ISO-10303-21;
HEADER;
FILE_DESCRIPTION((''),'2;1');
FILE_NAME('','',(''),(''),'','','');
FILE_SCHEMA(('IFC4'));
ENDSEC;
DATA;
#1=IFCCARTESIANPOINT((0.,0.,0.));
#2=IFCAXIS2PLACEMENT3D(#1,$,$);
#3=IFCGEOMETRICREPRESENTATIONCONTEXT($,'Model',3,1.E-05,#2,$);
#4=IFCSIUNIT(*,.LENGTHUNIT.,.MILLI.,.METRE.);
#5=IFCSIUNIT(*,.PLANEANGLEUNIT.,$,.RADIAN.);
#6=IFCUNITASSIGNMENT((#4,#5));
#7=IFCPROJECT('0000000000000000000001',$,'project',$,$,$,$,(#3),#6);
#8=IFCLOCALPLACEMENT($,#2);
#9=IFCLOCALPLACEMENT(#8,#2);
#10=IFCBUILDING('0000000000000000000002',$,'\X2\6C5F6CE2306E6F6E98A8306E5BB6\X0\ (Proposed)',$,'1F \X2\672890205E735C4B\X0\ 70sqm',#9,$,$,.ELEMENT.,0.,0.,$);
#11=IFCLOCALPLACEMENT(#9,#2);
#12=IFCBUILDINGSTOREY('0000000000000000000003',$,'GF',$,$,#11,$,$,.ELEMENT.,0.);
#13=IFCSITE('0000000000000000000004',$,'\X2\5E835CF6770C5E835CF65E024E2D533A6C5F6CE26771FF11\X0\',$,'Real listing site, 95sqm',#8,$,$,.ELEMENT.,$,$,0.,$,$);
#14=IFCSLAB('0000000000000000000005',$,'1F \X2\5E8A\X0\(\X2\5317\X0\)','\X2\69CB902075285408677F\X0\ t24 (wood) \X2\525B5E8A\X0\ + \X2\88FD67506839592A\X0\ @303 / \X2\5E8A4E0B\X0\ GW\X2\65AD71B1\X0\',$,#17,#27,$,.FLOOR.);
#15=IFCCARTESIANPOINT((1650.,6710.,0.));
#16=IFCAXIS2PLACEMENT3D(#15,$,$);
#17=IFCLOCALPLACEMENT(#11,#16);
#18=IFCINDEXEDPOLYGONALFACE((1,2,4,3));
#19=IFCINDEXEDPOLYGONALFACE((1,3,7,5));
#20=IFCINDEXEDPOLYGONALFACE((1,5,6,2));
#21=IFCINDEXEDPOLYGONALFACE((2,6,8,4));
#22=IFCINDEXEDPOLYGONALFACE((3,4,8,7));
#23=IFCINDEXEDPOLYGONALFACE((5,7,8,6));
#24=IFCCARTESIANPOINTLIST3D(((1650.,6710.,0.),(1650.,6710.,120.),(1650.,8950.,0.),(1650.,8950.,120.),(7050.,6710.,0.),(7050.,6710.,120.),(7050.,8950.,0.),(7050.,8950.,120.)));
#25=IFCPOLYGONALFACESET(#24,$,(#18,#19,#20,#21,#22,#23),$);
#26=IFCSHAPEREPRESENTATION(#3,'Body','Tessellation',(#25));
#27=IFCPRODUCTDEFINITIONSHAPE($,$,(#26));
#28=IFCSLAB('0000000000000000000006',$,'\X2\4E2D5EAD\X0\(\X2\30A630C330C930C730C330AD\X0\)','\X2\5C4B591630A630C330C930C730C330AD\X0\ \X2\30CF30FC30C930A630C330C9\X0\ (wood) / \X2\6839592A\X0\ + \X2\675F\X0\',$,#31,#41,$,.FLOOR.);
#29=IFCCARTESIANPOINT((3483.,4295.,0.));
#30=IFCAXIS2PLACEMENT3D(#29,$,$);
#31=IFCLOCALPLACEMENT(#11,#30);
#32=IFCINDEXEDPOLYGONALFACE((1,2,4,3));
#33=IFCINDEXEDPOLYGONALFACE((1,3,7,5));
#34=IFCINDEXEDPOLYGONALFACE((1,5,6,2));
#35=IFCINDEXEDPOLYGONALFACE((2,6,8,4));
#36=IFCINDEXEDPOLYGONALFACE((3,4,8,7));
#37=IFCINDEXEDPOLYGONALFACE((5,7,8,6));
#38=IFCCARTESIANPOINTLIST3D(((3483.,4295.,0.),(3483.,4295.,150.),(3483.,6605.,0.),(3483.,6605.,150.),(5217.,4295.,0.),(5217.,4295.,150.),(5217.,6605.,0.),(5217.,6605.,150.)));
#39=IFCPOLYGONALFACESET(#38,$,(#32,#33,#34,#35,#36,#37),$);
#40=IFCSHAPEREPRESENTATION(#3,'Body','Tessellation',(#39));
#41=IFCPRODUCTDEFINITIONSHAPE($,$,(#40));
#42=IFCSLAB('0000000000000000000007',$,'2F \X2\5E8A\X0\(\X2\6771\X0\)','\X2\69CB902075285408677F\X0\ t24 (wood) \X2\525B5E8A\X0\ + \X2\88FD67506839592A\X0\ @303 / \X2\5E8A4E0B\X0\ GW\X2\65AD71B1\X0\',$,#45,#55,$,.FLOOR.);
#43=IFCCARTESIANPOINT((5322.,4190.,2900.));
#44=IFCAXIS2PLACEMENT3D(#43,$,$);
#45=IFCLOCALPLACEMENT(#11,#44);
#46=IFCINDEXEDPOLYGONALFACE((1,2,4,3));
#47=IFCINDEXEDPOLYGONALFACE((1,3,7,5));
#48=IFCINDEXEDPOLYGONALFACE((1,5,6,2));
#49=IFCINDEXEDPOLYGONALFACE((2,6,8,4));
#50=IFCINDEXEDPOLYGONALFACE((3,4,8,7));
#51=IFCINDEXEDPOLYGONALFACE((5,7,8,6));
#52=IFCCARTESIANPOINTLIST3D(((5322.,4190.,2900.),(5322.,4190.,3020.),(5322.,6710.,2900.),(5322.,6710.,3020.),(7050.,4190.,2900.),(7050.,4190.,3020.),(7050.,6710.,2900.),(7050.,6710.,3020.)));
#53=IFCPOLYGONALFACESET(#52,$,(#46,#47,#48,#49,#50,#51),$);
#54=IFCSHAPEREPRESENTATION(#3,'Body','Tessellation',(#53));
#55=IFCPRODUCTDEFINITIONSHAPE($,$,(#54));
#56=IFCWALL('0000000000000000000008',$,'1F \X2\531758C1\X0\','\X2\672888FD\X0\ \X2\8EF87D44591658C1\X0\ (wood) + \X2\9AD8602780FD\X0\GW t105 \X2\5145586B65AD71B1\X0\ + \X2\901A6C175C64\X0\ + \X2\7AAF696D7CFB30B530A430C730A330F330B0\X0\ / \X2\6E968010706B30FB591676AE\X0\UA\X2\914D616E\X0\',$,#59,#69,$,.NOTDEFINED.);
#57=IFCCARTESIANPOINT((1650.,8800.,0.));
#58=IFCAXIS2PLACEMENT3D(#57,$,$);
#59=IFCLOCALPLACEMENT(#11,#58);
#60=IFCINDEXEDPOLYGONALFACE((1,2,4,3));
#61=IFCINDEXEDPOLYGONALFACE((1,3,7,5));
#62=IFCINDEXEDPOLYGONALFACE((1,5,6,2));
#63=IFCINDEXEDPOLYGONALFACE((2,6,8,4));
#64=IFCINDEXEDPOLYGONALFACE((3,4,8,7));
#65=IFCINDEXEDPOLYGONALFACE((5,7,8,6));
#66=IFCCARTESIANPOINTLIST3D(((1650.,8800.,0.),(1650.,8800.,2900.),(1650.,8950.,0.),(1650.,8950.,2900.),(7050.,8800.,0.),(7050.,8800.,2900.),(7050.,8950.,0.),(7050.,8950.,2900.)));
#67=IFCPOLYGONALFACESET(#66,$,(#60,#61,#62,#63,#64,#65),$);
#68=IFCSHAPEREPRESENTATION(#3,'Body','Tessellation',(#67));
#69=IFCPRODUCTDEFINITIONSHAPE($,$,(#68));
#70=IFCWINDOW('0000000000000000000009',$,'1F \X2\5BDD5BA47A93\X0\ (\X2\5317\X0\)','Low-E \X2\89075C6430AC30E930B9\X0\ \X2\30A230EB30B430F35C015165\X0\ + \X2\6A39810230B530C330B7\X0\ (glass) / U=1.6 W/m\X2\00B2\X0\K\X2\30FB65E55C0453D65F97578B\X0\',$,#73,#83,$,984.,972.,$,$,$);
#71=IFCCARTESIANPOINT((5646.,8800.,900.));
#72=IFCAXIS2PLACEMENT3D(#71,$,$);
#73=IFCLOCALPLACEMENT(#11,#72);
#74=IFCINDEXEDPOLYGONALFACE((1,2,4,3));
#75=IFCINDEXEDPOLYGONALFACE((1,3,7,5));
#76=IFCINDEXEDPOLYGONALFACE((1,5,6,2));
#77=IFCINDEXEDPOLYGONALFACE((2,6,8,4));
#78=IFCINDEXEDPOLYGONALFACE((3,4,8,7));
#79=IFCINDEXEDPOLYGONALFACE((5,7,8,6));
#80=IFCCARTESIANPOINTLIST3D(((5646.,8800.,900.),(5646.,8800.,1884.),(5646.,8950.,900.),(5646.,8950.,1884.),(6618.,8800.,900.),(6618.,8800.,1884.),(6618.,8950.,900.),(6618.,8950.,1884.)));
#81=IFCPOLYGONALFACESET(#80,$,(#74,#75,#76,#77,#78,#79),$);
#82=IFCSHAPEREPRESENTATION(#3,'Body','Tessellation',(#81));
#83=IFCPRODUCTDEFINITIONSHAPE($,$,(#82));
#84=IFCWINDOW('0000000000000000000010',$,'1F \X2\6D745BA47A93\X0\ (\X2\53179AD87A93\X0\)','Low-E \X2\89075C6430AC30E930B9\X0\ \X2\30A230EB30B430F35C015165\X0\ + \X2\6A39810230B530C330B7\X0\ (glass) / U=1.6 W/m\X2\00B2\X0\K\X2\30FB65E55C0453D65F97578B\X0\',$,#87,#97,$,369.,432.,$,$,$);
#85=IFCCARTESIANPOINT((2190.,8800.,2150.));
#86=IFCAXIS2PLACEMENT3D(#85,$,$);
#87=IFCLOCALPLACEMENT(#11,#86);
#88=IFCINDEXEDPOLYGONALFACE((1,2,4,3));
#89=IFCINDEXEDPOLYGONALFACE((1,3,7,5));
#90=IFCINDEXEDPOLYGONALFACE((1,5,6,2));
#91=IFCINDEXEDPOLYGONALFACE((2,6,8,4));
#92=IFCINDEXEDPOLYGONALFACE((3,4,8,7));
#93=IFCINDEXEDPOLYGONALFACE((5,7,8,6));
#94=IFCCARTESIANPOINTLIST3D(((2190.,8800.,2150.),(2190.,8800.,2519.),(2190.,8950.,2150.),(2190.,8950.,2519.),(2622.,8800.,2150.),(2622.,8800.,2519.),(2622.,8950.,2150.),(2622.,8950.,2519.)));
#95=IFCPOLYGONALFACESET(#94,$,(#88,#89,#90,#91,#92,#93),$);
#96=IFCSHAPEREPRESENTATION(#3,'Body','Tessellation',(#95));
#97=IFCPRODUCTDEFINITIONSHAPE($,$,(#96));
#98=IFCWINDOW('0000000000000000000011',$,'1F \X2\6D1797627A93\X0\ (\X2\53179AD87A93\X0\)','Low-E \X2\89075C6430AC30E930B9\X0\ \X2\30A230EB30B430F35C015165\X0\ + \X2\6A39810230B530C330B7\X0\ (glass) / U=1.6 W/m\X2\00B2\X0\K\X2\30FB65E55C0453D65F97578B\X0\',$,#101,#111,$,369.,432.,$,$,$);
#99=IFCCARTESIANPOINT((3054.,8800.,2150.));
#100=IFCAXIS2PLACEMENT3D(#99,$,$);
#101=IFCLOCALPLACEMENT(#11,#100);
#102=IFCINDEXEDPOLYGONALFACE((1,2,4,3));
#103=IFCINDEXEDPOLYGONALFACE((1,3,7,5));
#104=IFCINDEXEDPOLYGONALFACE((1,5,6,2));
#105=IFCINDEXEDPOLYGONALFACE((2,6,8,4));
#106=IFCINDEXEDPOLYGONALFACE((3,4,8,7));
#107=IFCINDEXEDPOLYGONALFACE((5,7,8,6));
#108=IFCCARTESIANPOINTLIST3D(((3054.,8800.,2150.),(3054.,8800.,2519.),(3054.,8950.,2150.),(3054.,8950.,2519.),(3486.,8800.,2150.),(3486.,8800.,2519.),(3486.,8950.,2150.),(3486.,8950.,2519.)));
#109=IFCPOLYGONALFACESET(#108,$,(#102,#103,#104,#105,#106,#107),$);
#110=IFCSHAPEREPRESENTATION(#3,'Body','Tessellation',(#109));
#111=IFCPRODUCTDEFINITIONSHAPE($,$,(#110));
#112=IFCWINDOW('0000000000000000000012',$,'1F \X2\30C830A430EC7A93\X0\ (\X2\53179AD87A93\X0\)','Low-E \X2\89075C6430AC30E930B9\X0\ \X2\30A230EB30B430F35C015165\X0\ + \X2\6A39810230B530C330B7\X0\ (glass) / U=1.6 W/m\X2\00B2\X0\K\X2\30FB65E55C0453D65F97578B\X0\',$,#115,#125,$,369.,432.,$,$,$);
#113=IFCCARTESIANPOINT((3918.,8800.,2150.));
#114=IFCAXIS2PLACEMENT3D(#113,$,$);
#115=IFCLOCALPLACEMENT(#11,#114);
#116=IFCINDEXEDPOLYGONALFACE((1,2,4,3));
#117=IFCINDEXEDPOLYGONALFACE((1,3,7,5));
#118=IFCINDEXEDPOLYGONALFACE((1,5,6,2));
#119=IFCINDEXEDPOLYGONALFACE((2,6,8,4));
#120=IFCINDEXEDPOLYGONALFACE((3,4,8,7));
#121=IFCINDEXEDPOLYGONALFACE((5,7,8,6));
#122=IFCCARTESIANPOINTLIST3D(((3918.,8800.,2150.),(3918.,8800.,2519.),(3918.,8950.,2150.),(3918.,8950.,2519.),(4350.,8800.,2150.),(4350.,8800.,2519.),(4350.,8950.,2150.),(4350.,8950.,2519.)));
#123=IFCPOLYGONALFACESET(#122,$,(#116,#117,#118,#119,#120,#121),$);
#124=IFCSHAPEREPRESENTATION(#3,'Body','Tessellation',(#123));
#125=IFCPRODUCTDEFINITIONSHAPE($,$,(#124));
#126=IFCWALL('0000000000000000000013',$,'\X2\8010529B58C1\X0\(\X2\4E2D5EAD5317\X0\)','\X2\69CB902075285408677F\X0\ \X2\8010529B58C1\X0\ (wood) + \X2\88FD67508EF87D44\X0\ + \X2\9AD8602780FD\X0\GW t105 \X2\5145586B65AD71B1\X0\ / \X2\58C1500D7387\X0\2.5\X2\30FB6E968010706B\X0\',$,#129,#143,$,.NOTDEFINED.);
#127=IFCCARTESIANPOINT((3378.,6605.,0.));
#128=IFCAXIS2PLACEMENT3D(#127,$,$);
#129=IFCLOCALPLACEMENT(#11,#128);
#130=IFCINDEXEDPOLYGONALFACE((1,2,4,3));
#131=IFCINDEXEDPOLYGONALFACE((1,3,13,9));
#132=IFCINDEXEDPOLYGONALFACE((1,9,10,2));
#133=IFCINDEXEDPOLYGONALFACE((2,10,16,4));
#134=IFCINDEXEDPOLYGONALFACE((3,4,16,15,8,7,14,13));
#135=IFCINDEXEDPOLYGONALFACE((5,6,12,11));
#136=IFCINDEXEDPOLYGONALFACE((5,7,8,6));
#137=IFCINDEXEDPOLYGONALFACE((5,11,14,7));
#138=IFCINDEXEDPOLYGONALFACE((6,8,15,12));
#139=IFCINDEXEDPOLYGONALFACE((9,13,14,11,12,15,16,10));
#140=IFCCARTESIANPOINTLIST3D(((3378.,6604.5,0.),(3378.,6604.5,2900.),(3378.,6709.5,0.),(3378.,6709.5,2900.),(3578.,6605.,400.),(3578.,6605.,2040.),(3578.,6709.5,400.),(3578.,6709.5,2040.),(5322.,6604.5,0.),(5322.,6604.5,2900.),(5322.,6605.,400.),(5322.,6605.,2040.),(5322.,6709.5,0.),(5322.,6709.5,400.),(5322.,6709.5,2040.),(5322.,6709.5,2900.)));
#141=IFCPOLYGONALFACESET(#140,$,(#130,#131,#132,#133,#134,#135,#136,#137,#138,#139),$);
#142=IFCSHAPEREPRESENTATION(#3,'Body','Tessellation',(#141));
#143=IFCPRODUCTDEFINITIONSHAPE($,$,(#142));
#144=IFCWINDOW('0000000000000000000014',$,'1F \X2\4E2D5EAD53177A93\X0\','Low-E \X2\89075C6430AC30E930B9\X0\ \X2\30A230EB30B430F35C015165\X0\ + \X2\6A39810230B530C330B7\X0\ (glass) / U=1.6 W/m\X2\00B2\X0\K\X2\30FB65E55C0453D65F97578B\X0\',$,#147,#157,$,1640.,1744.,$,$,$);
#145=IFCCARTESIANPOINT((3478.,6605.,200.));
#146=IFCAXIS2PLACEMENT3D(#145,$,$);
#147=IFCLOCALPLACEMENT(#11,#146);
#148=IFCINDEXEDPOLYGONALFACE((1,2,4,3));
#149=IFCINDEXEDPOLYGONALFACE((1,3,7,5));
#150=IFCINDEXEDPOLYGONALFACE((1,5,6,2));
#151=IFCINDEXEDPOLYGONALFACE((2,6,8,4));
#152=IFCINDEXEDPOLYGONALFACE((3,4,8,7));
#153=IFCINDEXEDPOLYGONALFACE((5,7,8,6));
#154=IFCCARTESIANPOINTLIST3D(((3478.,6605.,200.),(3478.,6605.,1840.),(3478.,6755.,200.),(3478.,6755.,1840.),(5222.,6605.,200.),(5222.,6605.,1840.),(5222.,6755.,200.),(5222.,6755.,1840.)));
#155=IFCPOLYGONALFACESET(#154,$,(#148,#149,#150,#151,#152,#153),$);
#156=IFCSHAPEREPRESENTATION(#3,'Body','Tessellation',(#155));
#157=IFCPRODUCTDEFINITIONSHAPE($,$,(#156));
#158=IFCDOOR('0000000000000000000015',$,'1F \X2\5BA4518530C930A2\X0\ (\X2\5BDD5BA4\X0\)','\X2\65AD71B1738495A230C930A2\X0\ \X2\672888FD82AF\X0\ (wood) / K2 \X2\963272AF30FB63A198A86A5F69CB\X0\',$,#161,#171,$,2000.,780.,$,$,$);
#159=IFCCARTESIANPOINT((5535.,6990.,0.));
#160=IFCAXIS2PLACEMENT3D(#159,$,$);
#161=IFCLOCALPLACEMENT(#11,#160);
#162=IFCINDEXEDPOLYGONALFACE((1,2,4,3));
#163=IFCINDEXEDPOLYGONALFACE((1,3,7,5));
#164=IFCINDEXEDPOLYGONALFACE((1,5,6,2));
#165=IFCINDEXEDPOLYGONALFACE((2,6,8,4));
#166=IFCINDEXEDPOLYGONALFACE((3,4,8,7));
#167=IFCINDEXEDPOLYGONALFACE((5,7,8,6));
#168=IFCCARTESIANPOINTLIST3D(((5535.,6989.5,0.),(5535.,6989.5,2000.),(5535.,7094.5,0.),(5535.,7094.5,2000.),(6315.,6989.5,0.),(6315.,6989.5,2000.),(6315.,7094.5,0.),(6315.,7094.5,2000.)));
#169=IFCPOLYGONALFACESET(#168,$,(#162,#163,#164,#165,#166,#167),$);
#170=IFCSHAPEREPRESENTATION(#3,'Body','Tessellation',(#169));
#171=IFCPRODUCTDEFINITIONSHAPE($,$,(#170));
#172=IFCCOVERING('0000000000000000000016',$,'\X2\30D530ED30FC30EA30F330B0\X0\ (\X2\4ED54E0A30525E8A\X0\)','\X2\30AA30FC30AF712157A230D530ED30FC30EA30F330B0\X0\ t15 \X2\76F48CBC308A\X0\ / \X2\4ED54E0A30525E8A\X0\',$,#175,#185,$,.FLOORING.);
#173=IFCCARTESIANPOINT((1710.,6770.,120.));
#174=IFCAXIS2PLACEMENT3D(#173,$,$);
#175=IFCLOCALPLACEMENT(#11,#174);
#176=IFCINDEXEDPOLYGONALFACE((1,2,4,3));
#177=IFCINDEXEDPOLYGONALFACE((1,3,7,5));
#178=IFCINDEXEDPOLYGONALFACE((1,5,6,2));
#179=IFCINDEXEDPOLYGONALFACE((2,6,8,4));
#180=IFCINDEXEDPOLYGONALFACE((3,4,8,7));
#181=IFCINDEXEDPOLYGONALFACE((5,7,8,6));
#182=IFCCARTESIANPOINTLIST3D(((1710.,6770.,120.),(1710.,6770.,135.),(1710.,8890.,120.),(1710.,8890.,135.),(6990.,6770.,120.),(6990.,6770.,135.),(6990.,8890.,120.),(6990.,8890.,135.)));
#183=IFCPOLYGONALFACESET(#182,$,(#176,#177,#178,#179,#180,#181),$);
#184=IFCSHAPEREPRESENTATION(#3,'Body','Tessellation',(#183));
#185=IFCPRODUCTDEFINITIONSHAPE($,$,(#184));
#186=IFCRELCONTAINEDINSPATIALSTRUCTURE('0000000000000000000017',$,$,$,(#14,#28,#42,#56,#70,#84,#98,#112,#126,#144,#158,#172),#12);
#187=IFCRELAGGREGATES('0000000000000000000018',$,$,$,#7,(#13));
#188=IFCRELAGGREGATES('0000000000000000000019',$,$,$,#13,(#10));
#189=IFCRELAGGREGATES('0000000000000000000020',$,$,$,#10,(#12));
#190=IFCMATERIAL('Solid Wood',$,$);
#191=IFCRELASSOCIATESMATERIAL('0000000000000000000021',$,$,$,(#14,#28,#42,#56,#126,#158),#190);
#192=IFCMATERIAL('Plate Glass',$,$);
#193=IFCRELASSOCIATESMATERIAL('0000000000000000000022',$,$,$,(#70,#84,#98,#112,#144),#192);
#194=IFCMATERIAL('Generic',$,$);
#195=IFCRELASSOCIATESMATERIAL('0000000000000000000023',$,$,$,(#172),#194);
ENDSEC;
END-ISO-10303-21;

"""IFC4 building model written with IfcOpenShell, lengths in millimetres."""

from ifc_helpers import new_model, si_unit, frame, frame_2d, origin, place, context, project, spatial, rectangle, extrude, material, element, fill, save


model = new_model("IFC4")

# Units and contexts
model_context = context("Model", 3, precision=1e-05, world=origin())
ifc_project = project(units=[si_unit("LENGTHUNIT", "METRE", prefix="MILLI"), si_unit("PLANEANGLEUNIT", "RADIAN")], contexts=[model_context])

# Site, building, storey
site_placement = place(None, origin())
site = spatial("IfcSite", under=ifc_project, at=site_placement, Name="広島県広島市中区江波東１", ObjectType="Real listing site, 95sqm", CompositionType="ELEMENT", RefElevation=0.0)
building_placement = place(site_placement, origin())
building = spatial("IfcBuilding", under=site, at=building_placement, Name="江波の潮風の家 (Proposed)", ObjectType="1F 木造平屋 70sqm", CompositionType="ELEMENT", ElevationOfRefHeight=0.0, ElevationOfTerrain=0.0)
storey_placement = place(building_placement, origin())
storey = spatial("IfcBuildingStorey", under=building, at=storey_placement, Name="GF", CompositionType="ELEMENT", Elevation=0.0)

# Slabs
ifc_material_1 = material(Name="Solid Wood")
slab_1_placement = place(storey_placement, frame((1650.0, 6710.0, 0.0)))
element("IfcSlab", 1, at=slab_1_placement, inside=storey, material=ifc_material_1, Name="1F 床(北)", Description="構造用合板 t24 (wood) 剛床 + 製材根太 @303 / 床下 GW断熱", PredefinedType="FLOOR", context=model_context, shape_type="SweptSolid", body=[
    extrude(rectangle(XDim=5400.0, YDim=2240.0, at=frame_2d((2700.0, 1120.0))), frame((1650.0, 6710.0, 0.0)), (0.0, 0.0, 1.0), 120.0),
])
slab_2_placement = place(storey_placement, frame((3483.0, 4295.0, 0.0)))
element("IfcSlab", 2, at=slab_2_placement, inside=storey, material=ifc_material_1, Name="中庭(ウッドデッキ)", Description="屋外ウッドデッキ ハードウッド (wood) / 根太 + 束", PredefinedType="FLOOR", context=model_context, shape_type="SweptSolid", body=[
    extrude(rectangle(XDim=1734.0, YDim=2310.0, at=frame_2d((867.0, 1155.0))), frame((3483.0, 4295.0, 0.0)), (0.0, 0.0, 1.0), 150.0),
])
slab_3_placement = place(storey_placement, frame((5322.0, 4190.0, 2900.0)))
element("IfcSlab", 3, at=slab_3_placement, inside=storey, material=ifc_material_1, Name="2F 床(東)", Description="構造用合板 t24 (wood) 剛床 + 製材根太 @303 / 床下 GW断熱", PredefinedType="FLOOR", context=model_context, shape_type="SweptSolid", body=[
    extrude(rectangle(XDim=1728.0, YDim=2520.0, at=frame_2d((864.0, 1260.0))), frame((5322.0, 4190.0, 2900.0)), (0.0, 0.0, 1.0), 120.0),
])

# Wall, openings, windows
wall_1_placement = place(storey_placement, frame((1650.0, 8800.0, 0.0)))
wall_1 = element("IfcWall", 4, at=wall_1_placement, inside=storey, material=ifc_material_1, Name="1F 北壁", Description="木製 軸組外壁 (wood) + 高性能GW t105 充填断熱 + 通気層 + 窯業系サイディング / 準耐火・外皮UA配慮", PredefinedType="NOTDEFINED", context=model_context, shape_type="SweptSolid", body=[
    extrude(rectangle(XDim=5400.0, YDim=150.0, at=frame_2d((2700.0, 75.0))), frame((1650.0, 8800.0, 0.0)), (0.0, 0.0, 1.0), 2900.0),
])
opening_1_placement = place(storey_placement, frame((5646.0, 8800.0, 900.0)))
opening_1 = element("IfcOpeningElement", 5, at=opening_1_placement, cuts=wall_1, PredefinedType="NOTDEFINED", context=model_context, shape_type="SweptSolid", body=[
    extrude(rectangle(XDim=972.0, YDim=150.0, at=frame_2d((486.0, 75.0))), frame((5646.0, 8800.0, 900.0)), (0.0, 0.0, 1.0), 984.0),
])
opening_2_placement = place(storey_placement, frame((2190.0, 8800.0, 2150.0)))
opening_2 = element("IfcOpeningElement", 6, at=opening_2_placement, cuts=wall_1, PredefinedType="NOTDEFINED", context=model_context, shape_type="SweptSolid", body=[
    extrude(rectangle(XDim=432.0, YDim=150.0, at=frame_2d((216.0, 75.0))), frame((2190.0, 8800.0, 2150.0)), (0.0, 0.0, 1.0), 369.0),
])
opening_3_placement = place(storey_placement, frame((3054.0, 8800.0, 2150.0)))
opening_3 = element("IfcOpeningElement", 7, at=opening_3_placement, cuts=wall_1, PredefinedType="NOTDEFINED", context=model_context, shape_type="SweptSolid", body=[
    extrude(rectangle(XDim=432.0, YDim=150.0, at=frame_2d((216.0, 75.0))), frame((3054.0, 8800.0, 2150.0)), (0.0, 0.0, 1.0), 369.0),
])
opening_4_placement = place(storey_placement, frame((3918.0, 8800.0, 2150.0)))
opening_4 = element("IfcOpeningElement", 8, at=opening_4_placement, cuts=wall_1, PredefinedType="NOTDEFINED", context=model_context, shape_type="SweptSolid", body=[
    extrude(rectangle(XDim=432.0, YDim=150.0, at=frame_2d((216.0, 75.0))), frame((3918.0, 8800.0, 2150.0)), (0.0, 0.0, 1.0), 369.0),
])
ifc_material_2 = material(Name="Plate Glass")
window_1_placement = place(storey_placement, frame((5646.0, 8800.0, 900.0)))
window_1 = element("IfcWindow", 9, at=window_1_placement, inside=storey, material=ifc_material_2, Name="1F 寝室窓 (北)", Description="Low-E 複層ガラス アルゴン封入 + 樹脂サッシ (glass) / U=1.6 W/m²K・日射取得型", OverallHeight=984.0, OverallWidth=972.0, context=model_context, shape_type="SweptSolid", body=[
    extrude(rectangle(XDim=972.0, YDim=150.0, at=frame_2d((486.0, 75.0))), frame((5646.0, 8800.0, 900.0)), (0.0, 0.0, 1.0), 984.0),
])
fill(opening_1, window_1)
window_2_placement = place(storey_placement, frame((2190.0, 8800.0, 2150.0)))
window_2 = element("IfcWindow", 10, at=window_2_placement, inside=storey, material=ifc_material_2, Name="1F 浴室窓 (北高窓)", Description="Low-E 複層ガラス アルゴン封入 + 樹脂サッシ (glass) / U=1.6 W/m²K・日射取得型", OverallHeight=369.0, OverallWidth=432.0, context=model_context, shape_type="SweptSolid", body=[
    extrude(rectangle(XDim=432.0, YDim=150.0, at=frame_2d((216.0, 75.0))), frame((2190.0, 8800.0, 2150.0)), (0.0, 0.0, 1.0), 369.0),
])
fill(opening_2, window_2)
window_3_placement = place(storey_placement, frame((3054.0, 8800.0, 2150.0)))
window_3 = element("IfcWindow", 11, at=window_3_placement, inside=storey, material=ifc_material_2, Name="1F 洗面窓 (北高窓)", Description="Low-E 複層ガラス アルゴン封入 + 樹脂サッシ (glass) / U=1.6 W/m²K・日射取得型", OverallHeight=369.0, OverallWidth=432.0, context=model_context, shape_type="SweptSolid", body=[
    extrude(rectangle(XDim=432.0, YDim=150.0, at=frame_2d((216.0, 75.0))), frame((3054.0, 8800.0, 2150.0)), (0.0, 0.0, 1.0), 369.0),
])
fill(opening_3, window_3)
window_4_placement = place(storey_placement, frame((3918.0, 8800.0, 2150.0)))
window_4 = element("IfcWindow", 12, at=window_4_placement, inside=storey, material=ifc_material_2, Name="1F トイレ窓 (北高窓)", Description="Low-E 複層ガラス アルゴン封入 + 樹脂サッシ (glass) / U=1.6 W/m²K・日射取得型", OverallHeight=369.0, OverallWidth=432.0, context=model_context, shape_type="SweptSolid", body=[
    extrude(rectangle(XDim=432.0, YDim=150.0, at=frame_2d((216.0, 75.0))), frame((3918.0, 8800.0, 2150.0)), (0.0, 0.0, 1.0), 369.0),
])
fill(opening_4, window_4)

# Wall, opening, window
wall_2_placement = place(storey_placement, frame((3378.0, 6605.0, 0.0)))
wall_2 = element("IfcWall", 13, at=wall_2_placement, inside=storey, material=ifc_material_1, Name="耐力壁(中庭北)", Description="構造用合板 耐力壁 (wood) + 製材軸組 + 高性能GW t105 充填断熱 / 壁倍率2.5・準耐火", PredefinedType="NOTDEFINED", context=model_context, shape_type="SweptSolid", body=[
    extrude(rectangle(XDim=1944.0, YDim=105.0, at=frame_2d((972.0, 52.0))), frame((3378.0, 6605.0, 0.0)), (0.0, 0.0, 1.0), 2900.0),
])
opening_5_placement = place(storey_placement, frame((3478.0, 6605.0, 200.0)))
opening_5 = element("IfcOpeningElement", 14, at=opening_5_placement, cuts=wall_2, PredefinedType="NOTDEFINED", context=model_context, shape_type="SweptSolid", body=[
    extrude(rectangle(XDim=1744.0, YDim=150.0, at=frame_2d((872.0, 75.0))), frame((3478.0, 6605.0, 200.0)), (0.0, 0.0, 1.0), 1640.0),
])
window_5_placement = place(storey_placement, frame((3478.0, 6605.0, 200.0)))
window_5 = element("IfcWindow", 15, at=window_5_placement, inside=storey, material=ifc_material_2, Name="1F 中庭北窓", Description="Low-E 複層ガラス アルゴン封入 + 樹脂サッシ (glass) / U=1.6 W/m²K・日射取得型", OverallHeight=1640.0, OverallWidth=1744.0, context=model_context, shape_type="SweptSolid", body=[
    extrude(rectangle(XDim=1744.0, YDim=150.0, at=frame_2d((872.0, 75.0))), frame((3478.0, 6605.0, 200.0)), (0.0, 0.0, 1.0), 1640.0),
])
fill(opening_5, window_5)

# Door
door_1_placement = place(storey_placement, frame((5535.0, 6990.0, 0.0)))
element("IfcDoor", 16, at=door_1_placement, inside=storey, material=ifc_material_1, Name="1F 室内ドア (寝室)", Description="断熱玄関ドア 木製芯 (wood) / K2 防犯・採風機構", OverallHeight=2000.0, OverallWidth=780.0, context=model_context, shape_type="SweptSolid", body=[
    extrude(rectangle(XDim=780.0, YDim=105.0, at=frame_2d((390.0, 52.0))), frame((5535.0, 6990.0, 0.0)), (0.0, 0.0, 1.0), 2000.0),
])

# Covering
ifc_material_3 = material(Name="Generic")
covering_1_placement = place(storey_placement, frame((1710.0, 6770.0, 120.0)))
element("IfcCovering", 17, at=covering_1_placement, inside=storey, material=ifc_material_3, Name="フローリング (仕上げ床)", Description="オーク無垢フローリング t15 直貼り / 仕上げ床", PredefinedType="FLOORING", context=model_context, shape_type="SweptSolid", body=[
    extrude(rectangle(XDim=5280.0, YDim=2120.0, at=frame_2d((2640.0, 1060.0))), frame((1710.0, 6770.0, 120.0)), (0.0, 0.0, 1.0), 15.0),
])

save(model, "model.ifc")
